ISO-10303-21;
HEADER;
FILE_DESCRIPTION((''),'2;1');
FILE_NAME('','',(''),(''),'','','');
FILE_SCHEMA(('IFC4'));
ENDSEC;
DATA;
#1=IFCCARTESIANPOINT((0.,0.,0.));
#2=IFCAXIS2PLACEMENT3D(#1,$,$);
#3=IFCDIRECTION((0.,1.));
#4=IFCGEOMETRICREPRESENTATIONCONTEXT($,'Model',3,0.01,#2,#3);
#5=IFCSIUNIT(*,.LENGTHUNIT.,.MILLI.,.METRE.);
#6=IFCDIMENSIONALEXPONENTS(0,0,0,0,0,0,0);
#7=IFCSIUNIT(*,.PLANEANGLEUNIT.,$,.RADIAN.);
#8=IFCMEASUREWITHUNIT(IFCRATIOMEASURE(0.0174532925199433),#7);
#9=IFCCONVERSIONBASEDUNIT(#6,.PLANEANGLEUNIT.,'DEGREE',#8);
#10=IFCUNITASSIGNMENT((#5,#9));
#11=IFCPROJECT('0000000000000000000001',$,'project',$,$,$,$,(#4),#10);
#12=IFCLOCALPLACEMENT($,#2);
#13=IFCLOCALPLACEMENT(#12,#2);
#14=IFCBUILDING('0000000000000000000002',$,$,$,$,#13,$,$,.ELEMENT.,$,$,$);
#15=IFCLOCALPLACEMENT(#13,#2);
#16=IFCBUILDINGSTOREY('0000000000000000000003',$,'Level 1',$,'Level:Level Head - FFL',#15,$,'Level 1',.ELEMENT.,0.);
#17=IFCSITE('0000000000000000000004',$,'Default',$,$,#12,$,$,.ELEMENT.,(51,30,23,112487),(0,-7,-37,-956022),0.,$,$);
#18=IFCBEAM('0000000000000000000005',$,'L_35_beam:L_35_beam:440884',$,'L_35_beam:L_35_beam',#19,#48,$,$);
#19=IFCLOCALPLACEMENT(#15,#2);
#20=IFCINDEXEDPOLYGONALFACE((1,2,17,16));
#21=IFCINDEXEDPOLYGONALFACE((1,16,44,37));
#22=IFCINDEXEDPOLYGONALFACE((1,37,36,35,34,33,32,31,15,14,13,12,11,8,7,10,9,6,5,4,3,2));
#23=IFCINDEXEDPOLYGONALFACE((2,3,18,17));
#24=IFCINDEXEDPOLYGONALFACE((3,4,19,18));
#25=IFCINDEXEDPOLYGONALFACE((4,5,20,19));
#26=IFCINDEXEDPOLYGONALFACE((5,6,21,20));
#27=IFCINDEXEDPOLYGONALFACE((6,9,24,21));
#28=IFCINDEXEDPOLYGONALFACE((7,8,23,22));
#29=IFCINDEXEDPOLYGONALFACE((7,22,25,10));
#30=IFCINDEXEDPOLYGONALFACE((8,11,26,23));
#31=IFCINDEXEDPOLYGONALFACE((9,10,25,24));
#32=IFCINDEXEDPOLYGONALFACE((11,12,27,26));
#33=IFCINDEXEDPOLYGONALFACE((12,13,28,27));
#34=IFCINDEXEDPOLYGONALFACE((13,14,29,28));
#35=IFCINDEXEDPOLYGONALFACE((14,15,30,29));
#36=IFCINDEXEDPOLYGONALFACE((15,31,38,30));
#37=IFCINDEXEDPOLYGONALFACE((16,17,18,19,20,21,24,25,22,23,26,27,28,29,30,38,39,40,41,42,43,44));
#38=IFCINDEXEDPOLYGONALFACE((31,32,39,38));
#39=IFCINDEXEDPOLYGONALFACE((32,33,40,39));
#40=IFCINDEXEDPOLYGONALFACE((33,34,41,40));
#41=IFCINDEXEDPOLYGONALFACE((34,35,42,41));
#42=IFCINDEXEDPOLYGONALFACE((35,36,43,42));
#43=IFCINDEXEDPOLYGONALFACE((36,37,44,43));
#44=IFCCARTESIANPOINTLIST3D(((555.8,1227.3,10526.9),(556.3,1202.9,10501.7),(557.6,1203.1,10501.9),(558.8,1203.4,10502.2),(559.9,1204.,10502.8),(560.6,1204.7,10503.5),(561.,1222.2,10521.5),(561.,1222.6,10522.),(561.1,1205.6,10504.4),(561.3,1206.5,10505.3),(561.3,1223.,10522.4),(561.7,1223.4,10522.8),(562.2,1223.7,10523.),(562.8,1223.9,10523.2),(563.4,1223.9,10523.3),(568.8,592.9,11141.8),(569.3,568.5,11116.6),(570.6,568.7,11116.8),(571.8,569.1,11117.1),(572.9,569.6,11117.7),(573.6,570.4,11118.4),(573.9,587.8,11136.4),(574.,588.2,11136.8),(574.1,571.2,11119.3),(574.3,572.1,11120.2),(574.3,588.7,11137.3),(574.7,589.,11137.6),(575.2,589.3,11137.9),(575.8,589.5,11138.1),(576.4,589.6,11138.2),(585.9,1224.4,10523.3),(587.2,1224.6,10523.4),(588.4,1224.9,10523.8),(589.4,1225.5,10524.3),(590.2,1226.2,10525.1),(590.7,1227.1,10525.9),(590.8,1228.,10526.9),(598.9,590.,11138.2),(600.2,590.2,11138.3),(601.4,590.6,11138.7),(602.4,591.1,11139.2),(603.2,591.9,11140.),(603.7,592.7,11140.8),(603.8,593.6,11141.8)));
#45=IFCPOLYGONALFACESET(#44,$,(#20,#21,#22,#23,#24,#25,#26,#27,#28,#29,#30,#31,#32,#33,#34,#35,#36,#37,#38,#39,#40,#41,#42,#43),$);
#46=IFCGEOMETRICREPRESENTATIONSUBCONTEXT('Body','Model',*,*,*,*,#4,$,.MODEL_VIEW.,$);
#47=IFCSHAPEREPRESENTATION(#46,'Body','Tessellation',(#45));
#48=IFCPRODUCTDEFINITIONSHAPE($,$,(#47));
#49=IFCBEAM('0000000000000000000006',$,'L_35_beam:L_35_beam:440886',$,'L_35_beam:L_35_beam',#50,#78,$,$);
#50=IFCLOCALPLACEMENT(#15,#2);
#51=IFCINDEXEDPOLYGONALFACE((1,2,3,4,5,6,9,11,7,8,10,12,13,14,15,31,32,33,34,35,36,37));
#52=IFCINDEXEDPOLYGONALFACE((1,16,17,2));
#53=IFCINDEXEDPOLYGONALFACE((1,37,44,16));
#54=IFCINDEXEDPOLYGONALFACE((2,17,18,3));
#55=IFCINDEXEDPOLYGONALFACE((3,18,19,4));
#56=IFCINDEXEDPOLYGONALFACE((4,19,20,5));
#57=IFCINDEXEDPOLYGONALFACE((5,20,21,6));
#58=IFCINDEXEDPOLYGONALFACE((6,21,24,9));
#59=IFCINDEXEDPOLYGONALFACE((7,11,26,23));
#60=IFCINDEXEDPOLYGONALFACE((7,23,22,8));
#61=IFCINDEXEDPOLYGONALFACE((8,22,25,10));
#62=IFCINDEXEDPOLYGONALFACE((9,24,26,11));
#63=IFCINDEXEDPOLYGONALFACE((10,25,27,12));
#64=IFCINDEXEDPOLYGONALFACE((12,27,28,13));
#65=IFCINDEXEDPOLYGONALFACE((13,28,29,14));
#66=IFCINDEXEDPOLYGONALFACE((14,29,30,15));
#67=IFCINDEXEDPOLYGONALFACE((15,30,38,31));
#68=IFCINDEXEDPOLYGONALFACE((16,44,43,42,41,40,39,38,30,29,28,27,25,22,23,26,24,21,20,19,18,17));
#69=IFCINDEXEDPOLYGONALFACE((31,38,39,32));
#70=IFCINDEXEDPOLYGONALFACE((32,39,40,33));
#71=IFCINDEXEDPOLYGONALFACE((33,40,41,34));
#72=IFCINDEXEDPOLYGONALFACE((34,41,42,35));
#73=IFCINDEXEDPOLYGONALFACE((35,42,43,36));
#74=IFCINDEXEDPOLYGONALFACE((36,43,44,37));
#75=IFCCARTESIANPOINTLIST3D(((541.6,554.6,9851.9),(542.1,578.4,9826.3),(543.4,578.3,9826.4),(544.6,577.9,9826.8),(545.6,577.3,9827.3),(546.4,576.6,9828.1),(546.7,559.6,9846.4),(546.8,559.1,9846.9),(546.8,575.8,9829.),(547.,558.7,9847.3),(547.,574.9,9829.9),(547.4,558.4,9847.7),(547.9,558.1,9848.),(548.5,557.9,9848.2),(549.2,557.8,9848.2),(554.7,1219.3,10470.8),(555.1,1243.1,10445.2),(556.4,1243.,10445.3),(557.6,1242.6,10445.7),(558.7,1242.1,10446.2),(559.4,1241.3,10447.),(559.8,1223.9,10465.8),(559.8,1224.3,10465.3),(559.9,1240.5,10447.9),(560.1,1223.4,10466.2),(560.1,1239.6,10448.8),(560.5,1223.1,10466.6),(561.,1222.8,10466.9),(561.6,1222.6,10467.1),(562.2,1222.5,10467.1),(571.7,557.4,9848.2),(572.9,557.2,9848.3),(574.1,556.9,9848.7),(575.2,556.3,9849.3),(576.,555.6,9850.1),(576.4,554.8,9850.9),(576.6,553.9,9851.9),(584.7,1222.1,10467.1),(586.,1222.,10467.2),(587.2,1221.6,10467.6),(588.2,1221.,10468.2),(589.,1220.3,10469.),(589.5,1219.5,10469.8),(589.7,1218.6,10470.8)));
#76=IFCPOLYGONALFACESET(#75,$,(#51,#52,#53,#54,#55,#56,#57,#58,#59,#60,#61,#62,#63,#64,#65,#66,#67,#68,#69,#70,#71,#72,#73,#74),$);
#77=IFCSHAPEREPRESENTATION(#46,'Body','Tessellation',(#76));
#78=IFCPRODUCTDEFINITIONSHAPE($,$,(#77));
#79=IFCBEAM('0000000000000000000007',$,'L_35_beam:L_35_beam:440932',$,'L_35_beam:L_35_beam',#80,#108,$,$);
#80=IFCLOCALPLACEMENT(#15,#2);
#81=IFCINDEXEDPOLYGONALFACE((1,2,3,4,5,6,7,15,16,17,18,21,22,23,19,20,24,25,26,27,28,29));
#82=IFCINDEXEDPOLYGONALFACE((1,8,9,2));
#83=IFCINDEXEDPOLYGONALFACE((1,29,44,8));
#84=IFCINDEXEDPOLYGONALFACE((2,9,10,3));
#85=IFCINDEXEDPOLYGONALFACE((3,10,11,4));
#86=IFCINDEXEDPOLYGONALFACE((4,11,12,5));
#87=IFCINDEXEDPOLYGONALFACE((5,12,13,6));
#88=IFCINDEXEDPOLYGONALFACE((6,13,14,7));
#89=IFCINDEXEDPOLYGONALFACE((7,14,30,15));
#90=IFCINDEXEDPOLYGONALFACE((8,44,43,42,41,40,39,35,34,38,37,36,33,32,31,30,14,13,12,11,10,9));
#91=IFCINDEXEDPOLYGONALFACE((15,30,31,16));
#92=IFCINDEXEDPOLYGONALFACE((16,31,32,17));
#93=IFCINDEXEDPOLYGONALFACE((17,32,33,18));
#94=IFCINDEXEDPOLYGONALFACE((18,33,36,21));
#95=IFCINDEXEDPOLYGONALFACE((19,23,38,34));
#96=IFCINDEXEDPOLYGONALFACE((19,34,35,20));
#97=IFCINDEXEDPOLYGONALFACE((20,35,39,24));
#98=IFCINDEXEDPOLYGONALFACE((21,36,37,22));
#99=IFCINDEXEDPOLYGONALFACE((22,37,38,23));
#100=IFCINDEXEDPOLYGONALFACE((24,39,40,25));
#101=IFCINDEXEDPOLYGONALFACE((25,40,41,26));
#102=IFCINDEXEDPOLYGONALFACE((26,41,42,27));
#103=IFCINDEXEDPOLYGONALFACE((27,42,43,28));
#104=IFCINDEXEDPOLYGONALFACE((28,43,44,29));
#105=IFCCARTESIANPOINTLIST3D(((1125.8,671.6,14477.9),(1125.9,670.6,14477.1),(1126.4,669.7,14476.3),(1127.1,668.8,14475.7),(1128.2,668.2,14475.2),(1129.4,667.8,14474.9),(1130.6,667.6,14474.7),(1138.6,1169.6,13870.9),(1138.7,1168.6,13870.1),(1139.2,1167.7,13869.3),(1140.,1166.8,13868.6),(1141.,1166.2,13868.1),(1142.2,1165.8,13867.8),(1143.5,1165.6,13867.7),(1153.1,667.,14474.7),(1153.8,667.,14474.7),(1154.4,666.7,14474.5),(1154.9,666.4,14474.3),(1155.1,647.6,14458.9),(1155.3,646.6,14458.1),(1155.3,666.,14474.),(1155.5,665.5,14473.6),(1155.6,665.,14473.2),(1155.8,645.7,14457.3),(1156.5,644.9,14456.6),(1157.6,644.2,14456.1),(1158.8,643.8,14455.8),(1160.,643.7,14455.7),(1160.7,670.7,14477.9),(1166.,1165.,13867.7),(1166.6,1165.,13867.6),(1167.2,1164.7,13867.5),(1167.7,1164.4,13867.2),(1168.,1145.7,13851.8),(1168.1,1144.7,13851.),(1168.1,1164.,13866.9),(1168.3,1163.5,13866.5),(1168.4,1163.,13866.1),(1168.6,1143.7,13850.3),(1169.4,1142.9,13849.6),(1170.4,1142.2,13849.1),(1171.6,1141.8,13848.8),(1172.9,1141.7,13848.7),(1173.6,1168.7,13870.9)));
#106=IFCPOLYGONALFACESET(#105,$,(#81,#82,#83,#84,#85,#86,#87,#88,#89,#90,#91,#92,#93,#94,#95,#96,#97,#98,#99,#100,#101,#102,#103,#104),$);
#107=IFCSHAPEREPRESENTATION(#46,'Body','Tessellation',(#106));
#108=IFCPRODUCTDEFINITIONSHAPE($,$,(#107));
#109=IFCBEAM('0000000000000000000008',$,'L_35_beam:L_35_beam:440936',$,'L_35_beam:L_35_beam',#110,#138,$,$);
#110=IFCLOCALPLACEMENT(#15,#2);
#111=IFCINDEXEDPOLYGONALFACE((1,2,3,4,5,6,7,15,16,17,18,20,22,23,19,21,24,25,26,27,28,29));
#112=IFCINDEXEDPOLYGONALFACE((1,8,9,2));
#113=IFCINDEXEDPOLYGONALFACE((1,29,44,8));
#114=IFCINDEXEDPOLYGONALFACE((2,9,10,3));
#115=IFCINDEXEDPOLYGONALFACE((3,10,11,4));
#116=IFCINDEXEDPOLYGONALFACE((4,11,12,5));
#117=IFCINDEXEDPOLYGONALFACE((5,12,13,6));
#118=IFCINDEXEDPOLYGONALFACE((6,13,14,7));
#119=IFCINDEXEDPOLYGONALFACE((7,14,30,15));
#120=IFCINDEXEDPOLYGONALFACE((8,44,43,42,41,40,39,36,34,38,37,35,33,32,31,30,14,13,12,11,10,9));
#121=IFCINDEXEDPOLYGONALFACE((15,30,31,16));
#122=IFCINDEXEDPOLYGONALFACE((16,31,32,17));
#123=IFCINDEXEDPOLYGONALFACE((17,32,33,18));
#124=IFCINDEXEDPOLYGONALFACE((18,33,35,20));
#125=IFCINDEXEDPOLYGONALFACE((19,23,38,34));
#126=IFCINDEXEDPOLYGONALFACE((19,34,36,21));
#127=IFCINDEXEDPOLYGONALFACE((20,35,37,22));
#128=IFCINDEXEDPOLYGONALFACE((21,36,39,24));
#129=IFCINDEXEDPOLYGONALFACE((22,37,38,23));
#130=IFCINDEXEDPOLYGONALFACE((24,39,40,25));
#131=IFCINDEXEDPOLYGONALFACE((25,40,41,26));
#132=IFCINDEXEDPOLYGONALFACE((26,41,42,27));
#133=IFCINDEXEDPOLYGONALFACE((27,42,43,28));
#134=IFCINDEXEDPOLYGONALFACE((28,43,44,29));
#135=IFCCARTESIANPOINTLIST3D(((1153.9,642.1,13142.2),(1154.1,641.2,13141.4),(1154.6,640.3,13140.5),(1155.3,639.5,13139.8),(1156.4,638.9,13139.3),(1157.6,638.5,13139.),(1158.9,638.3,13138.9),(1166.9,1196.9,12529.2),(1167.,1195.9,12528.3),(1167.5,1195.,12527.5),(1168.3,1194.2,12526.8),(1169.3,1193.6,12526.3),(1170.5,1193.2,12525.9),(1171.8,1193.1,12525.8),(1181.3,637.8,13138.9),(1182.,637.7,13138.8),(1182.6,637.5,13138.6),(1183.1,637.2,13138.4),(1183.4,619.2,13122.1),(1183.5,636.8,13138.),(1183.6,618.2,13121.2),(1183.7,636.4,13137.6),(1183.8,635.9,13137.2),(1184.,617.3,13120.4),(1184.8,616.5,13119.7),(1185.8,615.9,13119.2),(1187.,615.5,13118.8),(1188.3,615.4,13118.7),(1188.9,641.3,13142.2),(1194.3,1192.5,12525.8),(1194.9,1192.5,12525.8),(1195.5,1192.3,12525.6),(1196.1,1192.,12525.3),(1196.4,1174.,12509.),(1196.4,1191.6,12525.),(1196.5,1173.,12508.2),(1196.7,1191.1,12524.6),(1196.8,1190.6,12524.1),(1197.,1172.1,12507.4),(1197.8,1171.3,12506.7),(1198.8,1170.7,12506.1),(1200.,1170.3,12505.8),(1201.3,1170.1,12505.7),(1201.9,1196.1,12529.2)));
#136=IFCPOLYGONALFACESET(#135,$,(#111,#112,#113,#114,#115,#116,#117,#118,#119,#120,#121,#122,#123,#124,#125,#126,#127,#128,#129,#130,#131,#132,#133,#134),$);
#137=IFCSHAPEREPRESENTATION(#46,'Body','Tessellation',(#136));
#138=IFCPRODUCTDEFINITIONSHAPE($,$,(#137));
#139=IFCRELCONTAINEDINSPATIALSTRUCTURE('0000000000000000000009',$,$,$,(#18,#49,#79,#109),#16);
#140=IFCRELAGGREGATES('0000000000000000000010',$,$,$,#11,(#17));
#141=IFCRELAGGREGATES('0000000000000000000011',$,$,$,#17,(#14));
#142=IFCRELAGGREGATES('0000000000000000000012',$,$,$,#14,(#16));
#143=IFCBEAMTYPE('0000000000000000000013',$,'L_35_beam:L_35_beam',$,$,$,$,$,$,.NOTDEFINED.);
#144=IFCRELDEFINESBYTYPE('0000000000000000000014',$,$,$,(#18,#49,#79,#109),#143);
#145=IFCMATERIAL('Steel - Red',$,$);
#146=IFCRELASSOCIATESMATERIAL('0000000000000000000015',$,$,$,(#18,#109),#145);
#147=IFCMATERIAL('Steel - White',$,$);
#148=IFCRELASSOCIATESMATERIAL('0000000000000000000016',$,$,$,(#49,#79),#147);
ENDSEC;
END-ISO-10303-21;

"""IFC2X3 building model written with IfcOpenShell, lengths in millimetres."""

from ifc_helpers import new_model, entity, si_unit, converted_unit, direction, frame, frame_2d, origin, place, context, subcontext, project, spatial, polyline, circle_curve, parameter, trimmed, segment, composite_curve, outline, extrude, material, type_object, element, save


model = new_model("IFC2X3")

# Units and contexts
model_context = context("Model", 3, precision=0.01, world=origin(), true_north=direction((0.0, 1.0)))
body_context = subcontext(model_context, "Body", "Model", "MODEL_VIEW")
ifc_project = project(units=[si_unit("LENGTHUNIT", "METRE", prefix="MILLI"), converted_unit("PLANEANGLEUNIT", "DEGREE", entity("IfcRatioMeasure", 0.0174532925199433), si_unit("PLANEANGLEUNIT", "RADIAN"), dimensions=[0, 0, 0, 0, 0, 0, 0])], contexts=[model_context])

# Site, building, storey
site_placement = place(None, origin())
site = spatial("IfcSite", under=ifc_project, at=site_placement, Name="Default", CompositionType="ELEMENT", RefLatitude=(51, 30, 23, 112487), RefLongitude=(0, -7, -37, -956022), RefElevation=0.0)
building_placement = place(site_placement, origin())
building = spatial("IfcBuilding", under=site, at=building_placement, CompositionType="ELEMENT")
storey_placement = place(building_placement, origin())
storey = spatial("IfcBuildingStorey", under=building, at=storey_placement, Name="Level 1", ObjectType="Level:Level Head - FFL", LongName="Level 1", CompositionType="ELEMENT", Elevation=0.0)

# Beams
ifc_material_1 = material(Name="Steel - Red")
ifc_material_2 = material(Name="Steel - White")
beam_type_1 = type_object("IfcBeamType", Name="L_35_beam:L_35_beam", PredefinedType="NOTDEFINED")
beam_1_placement = place(storey_placement, frame((561.5, 561.5, 11147.6), z_axis=(-0.014249, 0.69577, 0.718123), x_axis=(-0.014704, 0.717973, -0.695916)))
element("IfcBeam", 1, at=beam_1_placement, inside=storey, type_object=beam_type_1, material=ifc_material_1, Name="L_35_beam:L_35_beam:440884", ObjectType="L_35_beam:L_35_beam", context=body_context, shape_type="SweptSolid", body=[
    extrude(outline(composite_curve([segment(polyline([(-23.2, -11.8), (11.8, -11.8)]), True, "CONTINUOUS"), segment(polyline([(11.8, -11.8), (11.8, 23.2)]), True, "CONTINUOUS"), segment(trimmed(circle_curve(frame_2d((11.8, 18.2), x_axis=(0.0, 1.0)), 5.0), [parameter(0.0)], [parameter(90.0)], True, "PARAMETER"), True, "CONTINUOUS"), segment(polyline([(6.8, 18.2), (6.8, -4.3)]), True, "CONTINUOUS"), segment(trimmed(circle_curve(frame_2d((4.3, -4.3), x_axis=(1.0, 0.0)), 2.5), [parameter(270.0)], [parameter(0.0)], True, "PARAMETER"), False, "CONTINUOUS"), segment(polyline([(4.3, -6.8), (-18.2, -6.8)]), True, "CONTINUOUS"), segment(trimmed(circle_curve(frame_2d((-18.2, -11.8), x_axis=(0.0, 1.0)), 5.0), [parameter(0.0)], [parameter(90.0)], True, "PARAMETER"), True, "CONTINUOUS")], self_intersect=False)), frame((26.5, -19.8, 5.7), z_axis=(1.0, 0.0, 0.0), x_axis=(0.0, 0.0, 1.0)), (0.0, 0.0, 1.0), 883.6),
])
beam_2_placement = place(storey_placement, frame((533.2, 533.2, 9807.9), z_axis=(-0.013402, -0.681234, 0.731943), x_axis=(0.014397, 0.731802, 0.681366)))
element("IfcBeam", 2, at=beam_2_placement, inside=storey, type_object=beam_type_1, material=ifc_material_2, Name="L_35_beam:L_35_beam:440886", ObjectType="L_35_beam:L_35_beam", context=body_context, shape_type="SweptSolid", body=[
    extrude(outline(composite_curve([segment(polyline([(-23.2, -11.8), (11.8, -11.8)]), True, "CONTINUOUS"), segment(polyline([(11.8, -11.8), (11.8, 23.2)]), True, "CONTINUOUS"), segment(trimmed(circle_curve(frame_2d((11.8, 18.2), x_axis=(0.0, 1.0)), 5.0), [parameter(0.0)], [parameter(90.0)], True, "PARAMETER"), True, "CONTINUOUS"), segment(polyline([(6.8, 18.2), (6.8, -4.3)]), True, "CONTINUOUS"), segment(trimmed(circle_curve(frame_2d((4.3, -4.3), x_axis=(1.0, 0.0)), 2.5), [parameter(270.0)], [parameter(0.0)], True, "PARAMETER"), False, "CONTINUOUS"), segment(polyline([(4.3, -6.8), (-18.2, -6.8)]), True, "CONTINUOUS"), segment(trimmed(circle_curve(frame_2d((-18.2, -11.8), x_axis=(0.0, 1.0)), 5.0), [parameter(0.0)], [parameter(90.0)], True, "PARAMETER"), True, "CONTINUOUS")], self_intersect=False)), frame((45.7, -19.8, 5.7), z_axis=(1.0, 0.0, 0.0), x_axis=(0.0, 0.0, 1.0)), (0.0, 0.0, 1.0), 908.3),
])
beam_3_placement = place(storey_placement, frame((1181.9, 1181.8, 13827.0), z_axis=(0.999867, -0.01036, 0.012628), x_axis=(-0.016334, -0.63417, 0.773021)))
element("IfcBeam", 3, at=beam_3_placement, inside=storey, type_object=beam_type_1, material=ifc_material_2, Name="L_35_beam:L_35_beam:440932", ObjectType="L_35_beam:L_35_beam", context=body_context, shape_type="SweptSolid", body=[
    extrude(outline(composite_curve([segment(polyline([(-23.2, -11.8), (11.8, -11.8)]), True, "CONTINUOUS"), segment(polyline([(11.8, -11.8), (11.8, 23.2)]), True, "CONTINUOUS"), segment(trimmed(circle_curve(frame_2d((11.8, 18.2), x_axis=(0.0, 1.0)), 5.0), [parameter(0.0)], [parameter(90.0)], True, "PARAMETER"), True, "CONTINUOUS"), segment(polyline([(6.8, 18.2), (6.8, -4.3)]), True, "CONTINUOUS"), segment(trimmed(circle_curve(frame_2d((4.3, -4.3), x_axis=(1.0, 0.0)), 2.5), [parameter(270.0)], [parameter(0.0)], True, "PARAMETER"), False, "CONTINUOUS"), segment(polyline([(4.3, -6.8), (-18.2, -6.8)]), True, "CONTINUOUS"), segment(trimmed(circle_curve(frame_2d((-18.2, -11.8), x_axis=(0.0, 1.0)), 5.0), [parameter(0.0)], [parameter(90.0)], True, "PARAMETER"), True, "CONTINUOUS")], self_intersect=False)), frame((42.4, -6.1, -19.7), z_axis=(1.0, 0.0, 0.0), x_axis=(0.0, -0.999802, 0.019906)), (0.0, 0.0, 1.0), 785.3),
])
beam_4_placement = place(storey_placement, frame((1210.2, 1210.2, 12487.3), z_axis=(0.999877, -0.010511, 0.011615), x_axis=(-0.015665, -0.670894, 0.741388)))
element("IfcBeam", 4, at=beam_4_placement, inside=storey, type_object=beam_type_1, material=ifc_material_1, Name="L_35_beam:L_35_beam:440936", ObjectType="L_35_beam:L_35_beam", context=body_context, shape_type="SweptSolid", body=[
    extrude(outline(composite_curve([segment(polyline([(-23.2, -11.8), (11.8, -11.8)]), True, "CONTINUOUS"), segment(polyline([(11.8, -11.8), (11.8, 23.2)]), True, "CONTINUOUS"), segment(trimmed(circle_curve(frame_2d((11.8, 18.2), x_axis=(0.0, 1.0)), 5.0), [parameter(0.0)], [parameter(90.0)], True, "PARAMETER"), True, "CONTINUOUS"), segment(polyline([(6.8, 18.2), (6.8, -4.3)]), True, "CONTINUOUS"), segment(trimmed(circle_curve(frame_2d((4.3, -4.3), x_axis=(1.0, 0.0)), 2.5), [parameter(270.0)], [parameter(0.0)], True, "PARAMETER"), False, "CONTINUOUS"), segment(polyline([(4.3, -6.8), (-18.2, -6.8)]), True, "CONTINUOUS"), segment(trimmed(circle_curve(frame_2d((-18.2, -11.8), x_axis=(0.0, 1.0)), 5.0), [parameter(0.0)], [parameter(90.0)], True, "PARAMETER"), True, "CONTINUOUS")], self_intersect=False)), frame((40.6, -6.1, -19.7), z_axis=(1.0, 0.0, 0.0), x_axis=(0.0, -0.99985, 0.017309)), (0.0, 0.0, 1.0), 826.9),
])

save(model, "model.ifc")
